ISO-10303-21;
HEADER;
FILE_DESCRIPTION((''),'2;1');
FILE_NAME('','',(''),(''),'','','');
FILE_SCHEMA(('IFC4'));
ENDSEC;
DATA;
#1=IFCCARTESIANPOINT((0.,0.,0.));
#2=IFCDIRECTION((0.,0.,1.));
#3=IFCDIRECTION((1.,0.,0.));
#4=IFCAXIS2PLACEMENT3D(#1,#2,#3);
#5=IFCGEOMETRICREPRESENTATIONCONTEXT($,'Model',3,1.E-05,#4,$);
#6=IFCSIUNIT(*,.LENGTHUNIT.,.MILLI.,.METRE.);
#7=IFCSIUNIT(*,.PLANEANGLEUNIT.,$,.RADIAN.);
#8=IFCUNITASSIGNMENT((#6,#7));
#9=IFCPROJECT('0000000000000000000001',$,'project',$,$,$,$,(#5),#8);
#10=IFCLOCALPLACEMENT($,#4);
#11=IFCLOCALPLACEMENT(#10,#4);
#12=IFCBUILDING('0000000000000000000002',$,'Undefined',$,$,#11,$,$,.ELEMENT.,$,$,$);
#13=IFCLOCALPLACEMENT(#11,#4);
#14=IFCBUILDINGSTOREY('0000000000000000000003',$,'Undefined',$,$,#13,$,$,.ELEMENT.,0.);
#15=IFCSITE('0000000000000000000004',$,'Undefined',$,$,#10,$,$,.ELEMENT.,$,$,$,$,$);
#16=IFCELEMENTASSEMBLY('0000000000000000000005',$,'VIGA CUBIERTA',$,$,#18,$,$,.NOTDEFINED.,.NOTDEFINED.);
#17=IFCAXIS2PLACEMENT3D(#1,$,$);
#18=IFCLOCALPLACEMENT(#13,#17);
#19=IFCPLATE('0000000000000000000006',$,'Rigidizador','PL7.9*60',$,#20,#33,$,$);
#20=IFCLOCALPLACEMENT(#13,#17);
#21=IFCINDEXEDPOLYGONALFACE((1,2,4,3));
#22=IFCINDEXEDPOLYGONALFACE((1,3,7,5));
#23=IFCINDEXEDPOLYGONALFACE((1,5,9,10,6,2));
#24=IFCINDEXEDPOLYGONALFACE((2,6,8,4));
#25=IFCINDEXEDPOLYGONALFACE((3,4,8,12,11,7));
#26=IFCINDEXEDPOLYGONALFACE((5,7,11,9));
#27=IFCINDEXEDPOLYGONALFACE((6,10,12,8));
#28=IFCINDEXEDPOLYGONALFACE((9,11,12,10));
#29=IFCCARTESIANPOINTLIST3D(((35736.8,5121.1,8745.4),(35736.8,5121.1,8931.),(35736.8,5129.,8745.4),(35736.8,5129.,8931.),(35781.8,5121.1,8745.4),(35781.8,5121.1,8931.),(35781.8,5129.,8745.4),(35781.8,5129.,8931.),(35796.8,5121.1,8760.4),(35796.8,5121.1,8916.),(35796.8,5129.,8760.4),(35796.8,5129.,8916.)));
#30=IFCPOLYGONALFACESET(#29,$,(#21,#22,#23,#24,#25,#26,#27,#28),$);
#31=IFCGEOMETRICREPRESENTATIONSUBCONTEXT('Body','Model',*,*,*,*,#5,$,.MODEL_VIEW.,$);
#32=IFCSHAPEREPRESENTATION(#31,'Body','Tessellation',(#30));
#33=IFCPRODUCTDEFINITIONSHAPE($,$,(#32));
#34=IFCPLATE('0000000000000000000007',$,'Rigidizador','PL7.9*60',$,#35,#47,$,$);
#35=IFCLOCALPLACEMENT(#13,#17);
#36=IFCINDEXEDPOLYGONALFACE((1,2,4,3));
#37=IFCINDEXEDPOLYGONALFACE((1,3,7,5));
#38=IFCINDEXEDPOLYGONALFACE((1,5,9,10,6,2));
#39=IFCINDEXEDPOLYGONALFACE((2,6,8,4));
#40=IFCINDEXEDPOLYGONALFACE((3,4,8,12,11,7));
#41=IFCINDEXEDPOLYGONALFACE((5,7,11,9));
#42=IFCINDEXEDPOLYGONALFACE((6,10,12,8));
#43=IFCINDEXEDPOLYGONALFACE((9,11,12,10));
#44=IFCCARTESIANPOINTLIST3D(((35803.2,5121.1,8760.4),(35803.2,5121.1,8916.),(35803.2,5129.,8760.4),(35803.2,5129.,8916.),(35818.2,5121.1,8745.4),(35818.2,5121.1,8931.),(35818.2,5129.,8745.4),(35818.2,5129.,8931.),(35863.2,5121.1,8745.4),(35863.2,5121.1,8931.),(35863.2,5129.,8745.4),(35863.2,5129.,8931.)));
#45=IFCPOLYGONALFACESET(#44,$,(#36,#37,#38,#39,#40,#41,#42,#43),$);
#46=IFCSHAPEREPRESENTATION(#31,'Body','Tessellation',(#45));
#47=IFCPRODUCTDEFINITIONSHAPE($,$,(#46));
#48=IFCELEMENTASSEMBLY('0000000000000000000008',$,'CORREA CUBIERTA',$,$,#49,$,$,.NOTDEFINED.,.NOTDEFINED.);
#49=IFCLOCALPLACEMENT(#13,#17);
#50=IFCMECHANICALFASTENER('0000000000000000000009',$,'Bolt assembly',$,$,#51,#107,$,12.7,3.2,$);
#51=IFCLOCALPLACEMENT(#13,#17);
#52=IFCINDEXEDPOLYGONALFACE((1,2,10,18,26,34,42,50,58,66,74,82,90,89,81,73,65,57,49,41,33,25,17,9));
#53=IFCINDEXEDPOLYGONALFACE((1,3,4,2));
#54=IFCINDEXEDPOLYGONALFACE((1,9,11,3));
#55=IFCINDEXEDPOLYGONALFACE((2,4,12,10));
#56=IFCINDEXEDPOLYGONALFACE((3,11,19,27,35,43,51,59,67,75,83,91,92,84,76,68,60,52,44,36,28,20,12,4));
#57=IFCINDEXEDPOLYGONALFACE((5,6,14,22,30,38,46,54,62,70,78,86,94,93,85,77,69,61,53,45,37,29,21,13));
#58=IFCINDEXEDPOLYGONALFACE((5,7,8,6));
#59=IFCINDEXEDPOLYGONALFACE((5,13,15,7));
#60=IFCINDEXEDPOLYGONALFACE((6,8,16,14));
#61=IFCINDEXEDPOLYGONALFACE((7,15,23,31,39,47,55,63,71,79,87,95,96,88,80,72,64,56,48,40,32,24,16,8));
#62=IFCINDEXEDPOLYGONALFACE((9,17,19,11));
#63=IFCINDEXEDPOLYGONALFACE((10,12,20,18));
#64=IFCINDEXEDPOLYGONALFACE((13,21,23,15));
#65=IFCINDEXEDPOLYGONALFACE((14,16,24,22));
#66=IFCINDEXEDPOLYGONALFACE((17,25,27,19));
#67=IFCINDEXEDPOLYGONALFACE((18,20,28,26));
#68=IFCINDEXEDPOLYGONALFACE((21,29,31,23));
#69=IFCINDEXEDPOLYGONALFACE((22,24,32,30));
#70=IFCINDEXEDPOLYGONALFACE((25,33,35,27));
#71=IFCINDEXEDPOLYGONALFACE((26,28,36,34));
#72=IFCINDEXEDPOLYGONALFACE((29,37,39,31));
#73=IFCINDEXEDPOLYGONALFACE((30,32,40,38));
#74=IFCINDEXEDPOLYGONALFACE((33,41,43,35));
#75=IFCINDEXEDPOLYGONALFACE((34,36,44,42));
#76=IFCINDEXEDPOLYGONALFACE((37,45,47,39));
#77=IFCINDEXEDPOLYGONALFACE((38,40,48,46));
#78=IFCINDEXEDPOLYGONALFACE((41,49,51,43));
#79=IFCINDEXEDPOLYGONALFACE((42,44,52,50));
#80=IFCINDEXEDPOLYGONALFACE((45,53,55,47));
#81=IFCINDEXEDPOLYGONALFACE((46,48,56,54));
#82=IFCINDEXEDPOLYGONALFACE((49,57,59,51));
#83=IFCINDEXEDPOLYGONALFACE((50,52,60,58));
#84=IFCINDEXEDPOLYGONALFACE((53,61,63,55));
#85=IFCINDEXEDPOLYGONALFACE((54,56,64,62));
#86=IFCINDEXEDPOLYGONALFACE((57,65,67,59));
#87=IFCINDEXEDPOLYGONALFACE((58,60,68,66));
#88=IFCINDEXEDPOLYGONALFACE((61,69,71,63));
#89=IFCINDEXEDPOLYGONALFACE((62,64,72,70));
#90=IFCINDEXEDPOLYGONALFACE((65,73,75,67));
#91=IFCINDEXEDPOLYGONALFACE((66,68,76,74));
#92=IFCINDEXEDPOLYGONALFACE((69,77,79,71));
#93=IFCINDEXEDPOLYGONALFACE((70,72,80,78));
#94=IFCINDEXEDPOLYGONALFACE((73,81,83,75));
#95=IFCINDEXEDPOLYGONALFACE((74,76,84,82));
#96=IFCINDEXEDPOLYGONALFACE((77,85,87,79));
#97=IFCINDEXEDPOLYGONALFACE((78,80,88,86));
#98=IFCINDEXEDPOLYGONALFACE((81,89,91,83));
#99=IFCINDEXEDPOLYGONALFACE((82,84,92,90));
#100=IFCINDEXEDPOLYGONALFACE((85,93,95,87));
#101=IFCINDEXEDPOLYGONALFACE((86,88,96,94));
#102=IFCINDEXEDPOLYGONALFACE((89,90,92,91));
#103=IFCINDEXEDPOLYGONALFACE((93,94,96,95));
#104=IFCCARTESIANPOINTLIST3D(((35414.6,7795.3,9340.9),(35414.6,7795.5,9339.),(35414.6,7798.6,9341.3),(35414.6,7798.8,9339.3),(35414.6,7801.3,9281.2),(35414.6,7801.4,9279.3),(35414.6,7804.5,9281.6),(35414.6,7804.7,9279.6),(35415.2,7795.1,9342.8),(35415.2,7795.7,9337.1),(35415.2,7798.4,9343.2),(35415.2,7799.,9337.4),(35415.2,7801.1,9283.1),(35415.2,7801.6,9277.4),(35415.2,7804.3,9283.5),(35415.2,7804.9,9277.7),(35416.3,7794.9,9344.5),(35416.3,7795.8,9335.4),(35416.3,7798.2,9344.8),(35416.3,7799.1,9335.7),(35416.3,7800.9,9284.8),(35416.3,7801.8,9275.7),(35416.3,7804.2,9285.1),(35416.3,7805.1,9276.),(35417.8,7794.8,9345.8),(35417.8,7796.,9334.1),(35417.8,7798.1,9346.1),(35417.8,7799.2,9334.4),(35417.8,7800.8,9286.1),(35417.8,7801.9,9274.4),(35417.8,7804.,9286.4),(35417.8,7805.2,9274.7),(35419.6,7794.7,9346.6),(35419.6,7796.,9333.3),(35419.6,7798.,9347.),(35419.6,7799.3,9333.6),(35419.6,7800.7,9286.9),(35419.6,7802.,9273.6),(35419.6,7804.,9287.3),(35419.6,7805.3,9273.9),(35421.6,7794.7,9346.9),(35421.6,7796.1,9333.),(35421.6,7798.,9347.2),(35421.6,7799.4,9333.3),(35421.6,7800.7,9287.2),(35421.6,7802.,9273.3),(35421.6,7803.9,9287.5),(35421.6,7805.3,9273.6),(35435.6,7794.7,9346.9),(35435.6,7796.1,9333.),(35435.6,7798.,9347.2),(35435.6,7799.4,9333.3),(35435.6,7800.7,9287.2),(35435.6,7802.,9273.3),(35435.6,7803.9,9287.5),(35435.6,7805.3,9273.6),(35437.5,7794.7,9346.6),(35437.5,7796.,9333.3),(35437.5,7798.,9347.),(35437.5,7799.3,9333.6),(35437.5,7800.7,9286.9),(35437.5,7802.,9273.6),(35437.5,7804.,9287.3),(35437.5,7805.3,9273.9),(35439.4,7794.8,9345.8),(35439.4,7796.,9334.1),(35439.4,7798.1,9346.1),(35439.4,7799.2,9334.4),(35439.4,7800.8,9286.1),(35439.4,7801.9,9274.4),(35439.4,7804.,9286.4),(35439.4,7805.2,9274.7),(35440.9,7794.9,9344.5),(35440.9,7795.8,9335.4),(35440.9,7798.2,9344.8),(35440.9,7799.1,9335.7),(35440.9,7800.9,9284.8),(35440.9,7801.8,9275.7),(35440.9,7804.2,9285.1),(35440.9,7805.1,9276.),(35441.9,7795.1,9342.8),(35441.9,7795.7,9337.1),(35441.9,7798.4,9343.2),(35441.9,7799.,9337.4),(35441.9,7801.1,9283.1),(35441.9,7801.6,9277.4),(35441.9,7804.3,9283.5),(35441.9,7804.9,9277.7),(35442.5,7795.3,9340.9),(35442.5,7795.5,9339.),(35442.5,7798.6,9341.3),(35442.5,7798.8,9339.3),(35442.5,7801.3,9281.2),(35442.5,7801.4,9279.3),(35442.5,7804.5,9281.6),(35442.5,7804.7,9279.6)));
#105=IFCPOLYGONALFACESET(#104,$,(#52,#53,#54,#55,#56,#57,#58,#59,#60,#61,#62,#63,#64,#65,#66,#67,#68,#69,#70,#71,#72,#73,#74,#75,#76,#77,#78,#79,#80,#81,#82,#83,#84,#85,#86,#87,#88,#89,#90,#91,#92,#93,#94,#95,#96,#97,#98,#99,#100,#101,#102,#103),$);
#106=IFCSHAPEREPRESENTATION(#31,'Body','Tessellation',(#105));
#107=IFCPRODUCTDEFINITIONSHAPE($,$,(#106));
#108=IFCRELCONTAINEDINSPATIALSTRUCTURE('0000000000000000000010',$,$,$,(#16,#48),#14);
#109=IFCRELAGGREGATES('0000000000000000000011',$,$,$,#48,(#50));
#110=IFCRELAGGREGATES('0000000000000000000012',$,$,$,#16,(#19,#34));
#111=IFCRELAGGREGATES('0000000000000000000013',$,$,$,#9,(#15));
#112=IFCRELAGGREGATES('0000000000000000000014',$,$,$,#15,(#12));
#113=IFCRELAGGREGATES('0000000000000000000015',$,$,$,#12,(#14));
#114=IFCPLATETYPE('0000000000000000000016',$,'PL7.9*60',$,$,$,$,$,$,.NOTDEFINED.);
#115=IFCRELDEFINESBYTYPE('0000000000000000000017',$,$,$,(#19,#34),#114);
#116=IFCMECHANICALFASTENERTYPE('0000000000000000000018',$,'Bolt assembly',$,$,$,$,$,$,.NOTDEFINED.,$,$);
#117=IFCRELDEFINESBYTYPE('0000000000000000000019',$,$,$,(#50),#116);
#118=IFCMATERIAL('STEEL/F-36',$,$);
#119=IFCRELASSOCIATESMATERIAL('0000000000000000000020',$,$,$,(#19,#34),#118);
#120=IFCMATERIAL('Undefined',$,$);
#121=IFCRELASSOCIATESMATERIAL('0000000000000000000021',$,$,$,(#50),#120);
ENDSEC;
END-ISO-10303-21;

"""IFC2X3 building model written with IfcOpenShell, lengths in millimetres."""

from ifc_helpers import new_model, si_unit, frame, frame_2d, origin_with_axes, place, context, subcontext, project, spatial, polyline, circle_curve, parameter, trimmed, segment, composite_curve, outline, extrude, source, transform, mapped, material, type_object, element, aggregate, save


model = new_model("IFC2X3")

# Units and contexts
model_context = context("Model", 3, precision=1e-05, world=origin_with_axes())
body_context = subcontext(model_context, "Body", "Model", "MODEL_VIEW")
ifc_project = project(units=[si_unit("LENGTHUNIT", "METRE", prefix="MILLI"), si_unit("PLANEANGLEUNIT", "RADIAN")], contexts=[model_context])

# Site, building, storey
site_placement = place(None, origin_with_axes())
site = spatial("IfcSite", under=ifc_project, at=site_placement, Name="Undefined", CompositionType="ELEMENT")
building_placement = place(site_placement, origin_with_axes())
building = spatial("IfcBuilding", under=site, at=building_placement, Name="Undefined", CompositionType="ELEMENT")
storey_placement = place(building_placement, origin_with_axes())
storey = spatial("IfcBuildingStorey", under=building, at=storey_placement, Name="Undefined", CompositionType="ELEMENT", Elevation=0.0)

# Element assembly
assembly_1_placement = place(storey_placement, origin_with_axes())
assembly_1 = element("IfcElementAssembly", 1, at=assembly_1_placement, inside=storey, Name="VIGA CUBIERTA", AssemblyPlace="NOTDEFINED", PredefinedType="NOTDEFINED")
ifc_material_1 = material(Name="STEEL/F-36")

# Plates
plate_type_1 = type_object("IfcPlateType", Name="PL7.9*60", PredefinedType="NOTDEFINED")
plate_1_placement = place(assembly_1_placement, frame((35736.8, 5125.0, 8745.4), z_axis=(0.0, -1.0, 0.0), x_axis=(1.0, 0.0, 0.0)))
plate_1 = element("IfcPlate", 2, at=plate_1_placement, type_object=plate_type_1, material=ifc_material_1, Name="Rigidizador", Description="PL7.9*60", context=body_context, shape_type="SweptSolid", body=[
    extrude(outline(polyline([(0.0, 0.0), (45.0, 0.0), (60.0, 15.0), (60.0, 170.6), (45.0, 185.6), (0.0, 185.6), (0.0, 0.0)])), frame((0.0, 0.0, -4.0), z_axis=(0.0, 0.0, 1.0), x_axis=(1.0, 0.0, 0.0)), (0.0, 0.0, 1.0), 7.9),
])
plate_2_placement = place(assembly_1_placement, frame((35803.2, 5125.0, 8745.4), z_axis=(0.0, -1.0, 0.0), x_axis=(1.0, 0.0, 0.0)))
plate_2 = element("IfcPlate", 3, at=plate_2_placement, type_object=plate_type_1, material=ifc_material_1, Name="Rigidizador", Description="PL7.9*60", context=body_context, shape_type="SweptSolid", body=[
    extrude(outline(polyline([(0.0, 15.0), (15.0, 0.0), (60.0, 0.0), (60.0, 185.6), (15.0, 185.6), (0.0, 170.6), (0.0, 15.0)])), frame((0.0, 0.0, -4.0), z_axis=(0.0, 0.0, 1.0), x_axis=(1.0, 0.0, 0.0)), (0.0, 0.0, 1.0), 7.9),
])

# Shared definitions
ifc_material_2 = material(Name="Undefined")
mechanical_fastener_type = type_object("IfcMechanicalFastenerType", Name="Bolt assembly")

# Element assembly, mechanical fastener
assembly_2_placement = place(storey_placement, origin_with_axes())
assembly_2 = element("IfcElementAssembly", 4, at=assembly_2_placement, inside=storey, Name="CORREA CUBIERTA", AssemblyPlace="NOTDEFINED", PredefinedType="NOTDEFINED")
shared_shape_1 = source(origin_with_axes(), body_context, "Body", "SweptSolid", [
    extrude(outline(composite_curve([segment(polyline([(7.0, 7.0), (7.0, -7.0)]), True, "CONTINUOUS"), segment(trimmed(circle_curve(frame_2d((0.0, -7.0), x_axis=(1.0, 0.0)), 7.0), [parameter(0.0)], [parameter(3.141593)], False, "PARAMETER"), True, "CONTINUOUS"), segment(polyline([(-7.0, -7.0), (-7.0, 7.0)]), True, "CONTINUOUS"), segment(trimmed(circle_curve(frame_2d((0.0, 7.0), x_axis=(-1.0, 0.0)), 7.0), [parameter(0.0)], [parameter(3.141593)], False, "PARAMETER"), True, "DISCONTINUOUS")], self_intersect=False)), frame((0.0, 3.2, 0.0), z_axis=(0.0, 1.0, 0.0), x_axis=(1.0, 0.0, 0.0)), (0.0, 0.0, 1.0), 3.3),
])
mechanical_fastener_1_placement = place(assembly_2_placement, frame((35428.6, 7801.9, 9340.6), z_axis=(-1.0, 0.0, 0.0), x_axis=(0.0, 0.099502, -0.995037)))
mechanical_fastener_1 = element("IfcMechanicalFastener", 5, at=mechanical_fastener_1_placement, type_object=mechanical_fastener_type, material=ifc_material_2, Name="Bolt assembly", NominalDiameter=12.7, NominalLength=3.2, context=body_context, shape_type="MappedRepresentation", body=[
    mapped(shared_shape_1, transform((0.0, 0.0, 0.0))),
    mapped(shared_shape_1, transform((60.0, 0.0, 0.0))),
])

aggregate(assembly_2, [mechanical_fastener_1])

aggregate(assembly_1, [plate_1, plate_2])

save(model, "model.ifc")
